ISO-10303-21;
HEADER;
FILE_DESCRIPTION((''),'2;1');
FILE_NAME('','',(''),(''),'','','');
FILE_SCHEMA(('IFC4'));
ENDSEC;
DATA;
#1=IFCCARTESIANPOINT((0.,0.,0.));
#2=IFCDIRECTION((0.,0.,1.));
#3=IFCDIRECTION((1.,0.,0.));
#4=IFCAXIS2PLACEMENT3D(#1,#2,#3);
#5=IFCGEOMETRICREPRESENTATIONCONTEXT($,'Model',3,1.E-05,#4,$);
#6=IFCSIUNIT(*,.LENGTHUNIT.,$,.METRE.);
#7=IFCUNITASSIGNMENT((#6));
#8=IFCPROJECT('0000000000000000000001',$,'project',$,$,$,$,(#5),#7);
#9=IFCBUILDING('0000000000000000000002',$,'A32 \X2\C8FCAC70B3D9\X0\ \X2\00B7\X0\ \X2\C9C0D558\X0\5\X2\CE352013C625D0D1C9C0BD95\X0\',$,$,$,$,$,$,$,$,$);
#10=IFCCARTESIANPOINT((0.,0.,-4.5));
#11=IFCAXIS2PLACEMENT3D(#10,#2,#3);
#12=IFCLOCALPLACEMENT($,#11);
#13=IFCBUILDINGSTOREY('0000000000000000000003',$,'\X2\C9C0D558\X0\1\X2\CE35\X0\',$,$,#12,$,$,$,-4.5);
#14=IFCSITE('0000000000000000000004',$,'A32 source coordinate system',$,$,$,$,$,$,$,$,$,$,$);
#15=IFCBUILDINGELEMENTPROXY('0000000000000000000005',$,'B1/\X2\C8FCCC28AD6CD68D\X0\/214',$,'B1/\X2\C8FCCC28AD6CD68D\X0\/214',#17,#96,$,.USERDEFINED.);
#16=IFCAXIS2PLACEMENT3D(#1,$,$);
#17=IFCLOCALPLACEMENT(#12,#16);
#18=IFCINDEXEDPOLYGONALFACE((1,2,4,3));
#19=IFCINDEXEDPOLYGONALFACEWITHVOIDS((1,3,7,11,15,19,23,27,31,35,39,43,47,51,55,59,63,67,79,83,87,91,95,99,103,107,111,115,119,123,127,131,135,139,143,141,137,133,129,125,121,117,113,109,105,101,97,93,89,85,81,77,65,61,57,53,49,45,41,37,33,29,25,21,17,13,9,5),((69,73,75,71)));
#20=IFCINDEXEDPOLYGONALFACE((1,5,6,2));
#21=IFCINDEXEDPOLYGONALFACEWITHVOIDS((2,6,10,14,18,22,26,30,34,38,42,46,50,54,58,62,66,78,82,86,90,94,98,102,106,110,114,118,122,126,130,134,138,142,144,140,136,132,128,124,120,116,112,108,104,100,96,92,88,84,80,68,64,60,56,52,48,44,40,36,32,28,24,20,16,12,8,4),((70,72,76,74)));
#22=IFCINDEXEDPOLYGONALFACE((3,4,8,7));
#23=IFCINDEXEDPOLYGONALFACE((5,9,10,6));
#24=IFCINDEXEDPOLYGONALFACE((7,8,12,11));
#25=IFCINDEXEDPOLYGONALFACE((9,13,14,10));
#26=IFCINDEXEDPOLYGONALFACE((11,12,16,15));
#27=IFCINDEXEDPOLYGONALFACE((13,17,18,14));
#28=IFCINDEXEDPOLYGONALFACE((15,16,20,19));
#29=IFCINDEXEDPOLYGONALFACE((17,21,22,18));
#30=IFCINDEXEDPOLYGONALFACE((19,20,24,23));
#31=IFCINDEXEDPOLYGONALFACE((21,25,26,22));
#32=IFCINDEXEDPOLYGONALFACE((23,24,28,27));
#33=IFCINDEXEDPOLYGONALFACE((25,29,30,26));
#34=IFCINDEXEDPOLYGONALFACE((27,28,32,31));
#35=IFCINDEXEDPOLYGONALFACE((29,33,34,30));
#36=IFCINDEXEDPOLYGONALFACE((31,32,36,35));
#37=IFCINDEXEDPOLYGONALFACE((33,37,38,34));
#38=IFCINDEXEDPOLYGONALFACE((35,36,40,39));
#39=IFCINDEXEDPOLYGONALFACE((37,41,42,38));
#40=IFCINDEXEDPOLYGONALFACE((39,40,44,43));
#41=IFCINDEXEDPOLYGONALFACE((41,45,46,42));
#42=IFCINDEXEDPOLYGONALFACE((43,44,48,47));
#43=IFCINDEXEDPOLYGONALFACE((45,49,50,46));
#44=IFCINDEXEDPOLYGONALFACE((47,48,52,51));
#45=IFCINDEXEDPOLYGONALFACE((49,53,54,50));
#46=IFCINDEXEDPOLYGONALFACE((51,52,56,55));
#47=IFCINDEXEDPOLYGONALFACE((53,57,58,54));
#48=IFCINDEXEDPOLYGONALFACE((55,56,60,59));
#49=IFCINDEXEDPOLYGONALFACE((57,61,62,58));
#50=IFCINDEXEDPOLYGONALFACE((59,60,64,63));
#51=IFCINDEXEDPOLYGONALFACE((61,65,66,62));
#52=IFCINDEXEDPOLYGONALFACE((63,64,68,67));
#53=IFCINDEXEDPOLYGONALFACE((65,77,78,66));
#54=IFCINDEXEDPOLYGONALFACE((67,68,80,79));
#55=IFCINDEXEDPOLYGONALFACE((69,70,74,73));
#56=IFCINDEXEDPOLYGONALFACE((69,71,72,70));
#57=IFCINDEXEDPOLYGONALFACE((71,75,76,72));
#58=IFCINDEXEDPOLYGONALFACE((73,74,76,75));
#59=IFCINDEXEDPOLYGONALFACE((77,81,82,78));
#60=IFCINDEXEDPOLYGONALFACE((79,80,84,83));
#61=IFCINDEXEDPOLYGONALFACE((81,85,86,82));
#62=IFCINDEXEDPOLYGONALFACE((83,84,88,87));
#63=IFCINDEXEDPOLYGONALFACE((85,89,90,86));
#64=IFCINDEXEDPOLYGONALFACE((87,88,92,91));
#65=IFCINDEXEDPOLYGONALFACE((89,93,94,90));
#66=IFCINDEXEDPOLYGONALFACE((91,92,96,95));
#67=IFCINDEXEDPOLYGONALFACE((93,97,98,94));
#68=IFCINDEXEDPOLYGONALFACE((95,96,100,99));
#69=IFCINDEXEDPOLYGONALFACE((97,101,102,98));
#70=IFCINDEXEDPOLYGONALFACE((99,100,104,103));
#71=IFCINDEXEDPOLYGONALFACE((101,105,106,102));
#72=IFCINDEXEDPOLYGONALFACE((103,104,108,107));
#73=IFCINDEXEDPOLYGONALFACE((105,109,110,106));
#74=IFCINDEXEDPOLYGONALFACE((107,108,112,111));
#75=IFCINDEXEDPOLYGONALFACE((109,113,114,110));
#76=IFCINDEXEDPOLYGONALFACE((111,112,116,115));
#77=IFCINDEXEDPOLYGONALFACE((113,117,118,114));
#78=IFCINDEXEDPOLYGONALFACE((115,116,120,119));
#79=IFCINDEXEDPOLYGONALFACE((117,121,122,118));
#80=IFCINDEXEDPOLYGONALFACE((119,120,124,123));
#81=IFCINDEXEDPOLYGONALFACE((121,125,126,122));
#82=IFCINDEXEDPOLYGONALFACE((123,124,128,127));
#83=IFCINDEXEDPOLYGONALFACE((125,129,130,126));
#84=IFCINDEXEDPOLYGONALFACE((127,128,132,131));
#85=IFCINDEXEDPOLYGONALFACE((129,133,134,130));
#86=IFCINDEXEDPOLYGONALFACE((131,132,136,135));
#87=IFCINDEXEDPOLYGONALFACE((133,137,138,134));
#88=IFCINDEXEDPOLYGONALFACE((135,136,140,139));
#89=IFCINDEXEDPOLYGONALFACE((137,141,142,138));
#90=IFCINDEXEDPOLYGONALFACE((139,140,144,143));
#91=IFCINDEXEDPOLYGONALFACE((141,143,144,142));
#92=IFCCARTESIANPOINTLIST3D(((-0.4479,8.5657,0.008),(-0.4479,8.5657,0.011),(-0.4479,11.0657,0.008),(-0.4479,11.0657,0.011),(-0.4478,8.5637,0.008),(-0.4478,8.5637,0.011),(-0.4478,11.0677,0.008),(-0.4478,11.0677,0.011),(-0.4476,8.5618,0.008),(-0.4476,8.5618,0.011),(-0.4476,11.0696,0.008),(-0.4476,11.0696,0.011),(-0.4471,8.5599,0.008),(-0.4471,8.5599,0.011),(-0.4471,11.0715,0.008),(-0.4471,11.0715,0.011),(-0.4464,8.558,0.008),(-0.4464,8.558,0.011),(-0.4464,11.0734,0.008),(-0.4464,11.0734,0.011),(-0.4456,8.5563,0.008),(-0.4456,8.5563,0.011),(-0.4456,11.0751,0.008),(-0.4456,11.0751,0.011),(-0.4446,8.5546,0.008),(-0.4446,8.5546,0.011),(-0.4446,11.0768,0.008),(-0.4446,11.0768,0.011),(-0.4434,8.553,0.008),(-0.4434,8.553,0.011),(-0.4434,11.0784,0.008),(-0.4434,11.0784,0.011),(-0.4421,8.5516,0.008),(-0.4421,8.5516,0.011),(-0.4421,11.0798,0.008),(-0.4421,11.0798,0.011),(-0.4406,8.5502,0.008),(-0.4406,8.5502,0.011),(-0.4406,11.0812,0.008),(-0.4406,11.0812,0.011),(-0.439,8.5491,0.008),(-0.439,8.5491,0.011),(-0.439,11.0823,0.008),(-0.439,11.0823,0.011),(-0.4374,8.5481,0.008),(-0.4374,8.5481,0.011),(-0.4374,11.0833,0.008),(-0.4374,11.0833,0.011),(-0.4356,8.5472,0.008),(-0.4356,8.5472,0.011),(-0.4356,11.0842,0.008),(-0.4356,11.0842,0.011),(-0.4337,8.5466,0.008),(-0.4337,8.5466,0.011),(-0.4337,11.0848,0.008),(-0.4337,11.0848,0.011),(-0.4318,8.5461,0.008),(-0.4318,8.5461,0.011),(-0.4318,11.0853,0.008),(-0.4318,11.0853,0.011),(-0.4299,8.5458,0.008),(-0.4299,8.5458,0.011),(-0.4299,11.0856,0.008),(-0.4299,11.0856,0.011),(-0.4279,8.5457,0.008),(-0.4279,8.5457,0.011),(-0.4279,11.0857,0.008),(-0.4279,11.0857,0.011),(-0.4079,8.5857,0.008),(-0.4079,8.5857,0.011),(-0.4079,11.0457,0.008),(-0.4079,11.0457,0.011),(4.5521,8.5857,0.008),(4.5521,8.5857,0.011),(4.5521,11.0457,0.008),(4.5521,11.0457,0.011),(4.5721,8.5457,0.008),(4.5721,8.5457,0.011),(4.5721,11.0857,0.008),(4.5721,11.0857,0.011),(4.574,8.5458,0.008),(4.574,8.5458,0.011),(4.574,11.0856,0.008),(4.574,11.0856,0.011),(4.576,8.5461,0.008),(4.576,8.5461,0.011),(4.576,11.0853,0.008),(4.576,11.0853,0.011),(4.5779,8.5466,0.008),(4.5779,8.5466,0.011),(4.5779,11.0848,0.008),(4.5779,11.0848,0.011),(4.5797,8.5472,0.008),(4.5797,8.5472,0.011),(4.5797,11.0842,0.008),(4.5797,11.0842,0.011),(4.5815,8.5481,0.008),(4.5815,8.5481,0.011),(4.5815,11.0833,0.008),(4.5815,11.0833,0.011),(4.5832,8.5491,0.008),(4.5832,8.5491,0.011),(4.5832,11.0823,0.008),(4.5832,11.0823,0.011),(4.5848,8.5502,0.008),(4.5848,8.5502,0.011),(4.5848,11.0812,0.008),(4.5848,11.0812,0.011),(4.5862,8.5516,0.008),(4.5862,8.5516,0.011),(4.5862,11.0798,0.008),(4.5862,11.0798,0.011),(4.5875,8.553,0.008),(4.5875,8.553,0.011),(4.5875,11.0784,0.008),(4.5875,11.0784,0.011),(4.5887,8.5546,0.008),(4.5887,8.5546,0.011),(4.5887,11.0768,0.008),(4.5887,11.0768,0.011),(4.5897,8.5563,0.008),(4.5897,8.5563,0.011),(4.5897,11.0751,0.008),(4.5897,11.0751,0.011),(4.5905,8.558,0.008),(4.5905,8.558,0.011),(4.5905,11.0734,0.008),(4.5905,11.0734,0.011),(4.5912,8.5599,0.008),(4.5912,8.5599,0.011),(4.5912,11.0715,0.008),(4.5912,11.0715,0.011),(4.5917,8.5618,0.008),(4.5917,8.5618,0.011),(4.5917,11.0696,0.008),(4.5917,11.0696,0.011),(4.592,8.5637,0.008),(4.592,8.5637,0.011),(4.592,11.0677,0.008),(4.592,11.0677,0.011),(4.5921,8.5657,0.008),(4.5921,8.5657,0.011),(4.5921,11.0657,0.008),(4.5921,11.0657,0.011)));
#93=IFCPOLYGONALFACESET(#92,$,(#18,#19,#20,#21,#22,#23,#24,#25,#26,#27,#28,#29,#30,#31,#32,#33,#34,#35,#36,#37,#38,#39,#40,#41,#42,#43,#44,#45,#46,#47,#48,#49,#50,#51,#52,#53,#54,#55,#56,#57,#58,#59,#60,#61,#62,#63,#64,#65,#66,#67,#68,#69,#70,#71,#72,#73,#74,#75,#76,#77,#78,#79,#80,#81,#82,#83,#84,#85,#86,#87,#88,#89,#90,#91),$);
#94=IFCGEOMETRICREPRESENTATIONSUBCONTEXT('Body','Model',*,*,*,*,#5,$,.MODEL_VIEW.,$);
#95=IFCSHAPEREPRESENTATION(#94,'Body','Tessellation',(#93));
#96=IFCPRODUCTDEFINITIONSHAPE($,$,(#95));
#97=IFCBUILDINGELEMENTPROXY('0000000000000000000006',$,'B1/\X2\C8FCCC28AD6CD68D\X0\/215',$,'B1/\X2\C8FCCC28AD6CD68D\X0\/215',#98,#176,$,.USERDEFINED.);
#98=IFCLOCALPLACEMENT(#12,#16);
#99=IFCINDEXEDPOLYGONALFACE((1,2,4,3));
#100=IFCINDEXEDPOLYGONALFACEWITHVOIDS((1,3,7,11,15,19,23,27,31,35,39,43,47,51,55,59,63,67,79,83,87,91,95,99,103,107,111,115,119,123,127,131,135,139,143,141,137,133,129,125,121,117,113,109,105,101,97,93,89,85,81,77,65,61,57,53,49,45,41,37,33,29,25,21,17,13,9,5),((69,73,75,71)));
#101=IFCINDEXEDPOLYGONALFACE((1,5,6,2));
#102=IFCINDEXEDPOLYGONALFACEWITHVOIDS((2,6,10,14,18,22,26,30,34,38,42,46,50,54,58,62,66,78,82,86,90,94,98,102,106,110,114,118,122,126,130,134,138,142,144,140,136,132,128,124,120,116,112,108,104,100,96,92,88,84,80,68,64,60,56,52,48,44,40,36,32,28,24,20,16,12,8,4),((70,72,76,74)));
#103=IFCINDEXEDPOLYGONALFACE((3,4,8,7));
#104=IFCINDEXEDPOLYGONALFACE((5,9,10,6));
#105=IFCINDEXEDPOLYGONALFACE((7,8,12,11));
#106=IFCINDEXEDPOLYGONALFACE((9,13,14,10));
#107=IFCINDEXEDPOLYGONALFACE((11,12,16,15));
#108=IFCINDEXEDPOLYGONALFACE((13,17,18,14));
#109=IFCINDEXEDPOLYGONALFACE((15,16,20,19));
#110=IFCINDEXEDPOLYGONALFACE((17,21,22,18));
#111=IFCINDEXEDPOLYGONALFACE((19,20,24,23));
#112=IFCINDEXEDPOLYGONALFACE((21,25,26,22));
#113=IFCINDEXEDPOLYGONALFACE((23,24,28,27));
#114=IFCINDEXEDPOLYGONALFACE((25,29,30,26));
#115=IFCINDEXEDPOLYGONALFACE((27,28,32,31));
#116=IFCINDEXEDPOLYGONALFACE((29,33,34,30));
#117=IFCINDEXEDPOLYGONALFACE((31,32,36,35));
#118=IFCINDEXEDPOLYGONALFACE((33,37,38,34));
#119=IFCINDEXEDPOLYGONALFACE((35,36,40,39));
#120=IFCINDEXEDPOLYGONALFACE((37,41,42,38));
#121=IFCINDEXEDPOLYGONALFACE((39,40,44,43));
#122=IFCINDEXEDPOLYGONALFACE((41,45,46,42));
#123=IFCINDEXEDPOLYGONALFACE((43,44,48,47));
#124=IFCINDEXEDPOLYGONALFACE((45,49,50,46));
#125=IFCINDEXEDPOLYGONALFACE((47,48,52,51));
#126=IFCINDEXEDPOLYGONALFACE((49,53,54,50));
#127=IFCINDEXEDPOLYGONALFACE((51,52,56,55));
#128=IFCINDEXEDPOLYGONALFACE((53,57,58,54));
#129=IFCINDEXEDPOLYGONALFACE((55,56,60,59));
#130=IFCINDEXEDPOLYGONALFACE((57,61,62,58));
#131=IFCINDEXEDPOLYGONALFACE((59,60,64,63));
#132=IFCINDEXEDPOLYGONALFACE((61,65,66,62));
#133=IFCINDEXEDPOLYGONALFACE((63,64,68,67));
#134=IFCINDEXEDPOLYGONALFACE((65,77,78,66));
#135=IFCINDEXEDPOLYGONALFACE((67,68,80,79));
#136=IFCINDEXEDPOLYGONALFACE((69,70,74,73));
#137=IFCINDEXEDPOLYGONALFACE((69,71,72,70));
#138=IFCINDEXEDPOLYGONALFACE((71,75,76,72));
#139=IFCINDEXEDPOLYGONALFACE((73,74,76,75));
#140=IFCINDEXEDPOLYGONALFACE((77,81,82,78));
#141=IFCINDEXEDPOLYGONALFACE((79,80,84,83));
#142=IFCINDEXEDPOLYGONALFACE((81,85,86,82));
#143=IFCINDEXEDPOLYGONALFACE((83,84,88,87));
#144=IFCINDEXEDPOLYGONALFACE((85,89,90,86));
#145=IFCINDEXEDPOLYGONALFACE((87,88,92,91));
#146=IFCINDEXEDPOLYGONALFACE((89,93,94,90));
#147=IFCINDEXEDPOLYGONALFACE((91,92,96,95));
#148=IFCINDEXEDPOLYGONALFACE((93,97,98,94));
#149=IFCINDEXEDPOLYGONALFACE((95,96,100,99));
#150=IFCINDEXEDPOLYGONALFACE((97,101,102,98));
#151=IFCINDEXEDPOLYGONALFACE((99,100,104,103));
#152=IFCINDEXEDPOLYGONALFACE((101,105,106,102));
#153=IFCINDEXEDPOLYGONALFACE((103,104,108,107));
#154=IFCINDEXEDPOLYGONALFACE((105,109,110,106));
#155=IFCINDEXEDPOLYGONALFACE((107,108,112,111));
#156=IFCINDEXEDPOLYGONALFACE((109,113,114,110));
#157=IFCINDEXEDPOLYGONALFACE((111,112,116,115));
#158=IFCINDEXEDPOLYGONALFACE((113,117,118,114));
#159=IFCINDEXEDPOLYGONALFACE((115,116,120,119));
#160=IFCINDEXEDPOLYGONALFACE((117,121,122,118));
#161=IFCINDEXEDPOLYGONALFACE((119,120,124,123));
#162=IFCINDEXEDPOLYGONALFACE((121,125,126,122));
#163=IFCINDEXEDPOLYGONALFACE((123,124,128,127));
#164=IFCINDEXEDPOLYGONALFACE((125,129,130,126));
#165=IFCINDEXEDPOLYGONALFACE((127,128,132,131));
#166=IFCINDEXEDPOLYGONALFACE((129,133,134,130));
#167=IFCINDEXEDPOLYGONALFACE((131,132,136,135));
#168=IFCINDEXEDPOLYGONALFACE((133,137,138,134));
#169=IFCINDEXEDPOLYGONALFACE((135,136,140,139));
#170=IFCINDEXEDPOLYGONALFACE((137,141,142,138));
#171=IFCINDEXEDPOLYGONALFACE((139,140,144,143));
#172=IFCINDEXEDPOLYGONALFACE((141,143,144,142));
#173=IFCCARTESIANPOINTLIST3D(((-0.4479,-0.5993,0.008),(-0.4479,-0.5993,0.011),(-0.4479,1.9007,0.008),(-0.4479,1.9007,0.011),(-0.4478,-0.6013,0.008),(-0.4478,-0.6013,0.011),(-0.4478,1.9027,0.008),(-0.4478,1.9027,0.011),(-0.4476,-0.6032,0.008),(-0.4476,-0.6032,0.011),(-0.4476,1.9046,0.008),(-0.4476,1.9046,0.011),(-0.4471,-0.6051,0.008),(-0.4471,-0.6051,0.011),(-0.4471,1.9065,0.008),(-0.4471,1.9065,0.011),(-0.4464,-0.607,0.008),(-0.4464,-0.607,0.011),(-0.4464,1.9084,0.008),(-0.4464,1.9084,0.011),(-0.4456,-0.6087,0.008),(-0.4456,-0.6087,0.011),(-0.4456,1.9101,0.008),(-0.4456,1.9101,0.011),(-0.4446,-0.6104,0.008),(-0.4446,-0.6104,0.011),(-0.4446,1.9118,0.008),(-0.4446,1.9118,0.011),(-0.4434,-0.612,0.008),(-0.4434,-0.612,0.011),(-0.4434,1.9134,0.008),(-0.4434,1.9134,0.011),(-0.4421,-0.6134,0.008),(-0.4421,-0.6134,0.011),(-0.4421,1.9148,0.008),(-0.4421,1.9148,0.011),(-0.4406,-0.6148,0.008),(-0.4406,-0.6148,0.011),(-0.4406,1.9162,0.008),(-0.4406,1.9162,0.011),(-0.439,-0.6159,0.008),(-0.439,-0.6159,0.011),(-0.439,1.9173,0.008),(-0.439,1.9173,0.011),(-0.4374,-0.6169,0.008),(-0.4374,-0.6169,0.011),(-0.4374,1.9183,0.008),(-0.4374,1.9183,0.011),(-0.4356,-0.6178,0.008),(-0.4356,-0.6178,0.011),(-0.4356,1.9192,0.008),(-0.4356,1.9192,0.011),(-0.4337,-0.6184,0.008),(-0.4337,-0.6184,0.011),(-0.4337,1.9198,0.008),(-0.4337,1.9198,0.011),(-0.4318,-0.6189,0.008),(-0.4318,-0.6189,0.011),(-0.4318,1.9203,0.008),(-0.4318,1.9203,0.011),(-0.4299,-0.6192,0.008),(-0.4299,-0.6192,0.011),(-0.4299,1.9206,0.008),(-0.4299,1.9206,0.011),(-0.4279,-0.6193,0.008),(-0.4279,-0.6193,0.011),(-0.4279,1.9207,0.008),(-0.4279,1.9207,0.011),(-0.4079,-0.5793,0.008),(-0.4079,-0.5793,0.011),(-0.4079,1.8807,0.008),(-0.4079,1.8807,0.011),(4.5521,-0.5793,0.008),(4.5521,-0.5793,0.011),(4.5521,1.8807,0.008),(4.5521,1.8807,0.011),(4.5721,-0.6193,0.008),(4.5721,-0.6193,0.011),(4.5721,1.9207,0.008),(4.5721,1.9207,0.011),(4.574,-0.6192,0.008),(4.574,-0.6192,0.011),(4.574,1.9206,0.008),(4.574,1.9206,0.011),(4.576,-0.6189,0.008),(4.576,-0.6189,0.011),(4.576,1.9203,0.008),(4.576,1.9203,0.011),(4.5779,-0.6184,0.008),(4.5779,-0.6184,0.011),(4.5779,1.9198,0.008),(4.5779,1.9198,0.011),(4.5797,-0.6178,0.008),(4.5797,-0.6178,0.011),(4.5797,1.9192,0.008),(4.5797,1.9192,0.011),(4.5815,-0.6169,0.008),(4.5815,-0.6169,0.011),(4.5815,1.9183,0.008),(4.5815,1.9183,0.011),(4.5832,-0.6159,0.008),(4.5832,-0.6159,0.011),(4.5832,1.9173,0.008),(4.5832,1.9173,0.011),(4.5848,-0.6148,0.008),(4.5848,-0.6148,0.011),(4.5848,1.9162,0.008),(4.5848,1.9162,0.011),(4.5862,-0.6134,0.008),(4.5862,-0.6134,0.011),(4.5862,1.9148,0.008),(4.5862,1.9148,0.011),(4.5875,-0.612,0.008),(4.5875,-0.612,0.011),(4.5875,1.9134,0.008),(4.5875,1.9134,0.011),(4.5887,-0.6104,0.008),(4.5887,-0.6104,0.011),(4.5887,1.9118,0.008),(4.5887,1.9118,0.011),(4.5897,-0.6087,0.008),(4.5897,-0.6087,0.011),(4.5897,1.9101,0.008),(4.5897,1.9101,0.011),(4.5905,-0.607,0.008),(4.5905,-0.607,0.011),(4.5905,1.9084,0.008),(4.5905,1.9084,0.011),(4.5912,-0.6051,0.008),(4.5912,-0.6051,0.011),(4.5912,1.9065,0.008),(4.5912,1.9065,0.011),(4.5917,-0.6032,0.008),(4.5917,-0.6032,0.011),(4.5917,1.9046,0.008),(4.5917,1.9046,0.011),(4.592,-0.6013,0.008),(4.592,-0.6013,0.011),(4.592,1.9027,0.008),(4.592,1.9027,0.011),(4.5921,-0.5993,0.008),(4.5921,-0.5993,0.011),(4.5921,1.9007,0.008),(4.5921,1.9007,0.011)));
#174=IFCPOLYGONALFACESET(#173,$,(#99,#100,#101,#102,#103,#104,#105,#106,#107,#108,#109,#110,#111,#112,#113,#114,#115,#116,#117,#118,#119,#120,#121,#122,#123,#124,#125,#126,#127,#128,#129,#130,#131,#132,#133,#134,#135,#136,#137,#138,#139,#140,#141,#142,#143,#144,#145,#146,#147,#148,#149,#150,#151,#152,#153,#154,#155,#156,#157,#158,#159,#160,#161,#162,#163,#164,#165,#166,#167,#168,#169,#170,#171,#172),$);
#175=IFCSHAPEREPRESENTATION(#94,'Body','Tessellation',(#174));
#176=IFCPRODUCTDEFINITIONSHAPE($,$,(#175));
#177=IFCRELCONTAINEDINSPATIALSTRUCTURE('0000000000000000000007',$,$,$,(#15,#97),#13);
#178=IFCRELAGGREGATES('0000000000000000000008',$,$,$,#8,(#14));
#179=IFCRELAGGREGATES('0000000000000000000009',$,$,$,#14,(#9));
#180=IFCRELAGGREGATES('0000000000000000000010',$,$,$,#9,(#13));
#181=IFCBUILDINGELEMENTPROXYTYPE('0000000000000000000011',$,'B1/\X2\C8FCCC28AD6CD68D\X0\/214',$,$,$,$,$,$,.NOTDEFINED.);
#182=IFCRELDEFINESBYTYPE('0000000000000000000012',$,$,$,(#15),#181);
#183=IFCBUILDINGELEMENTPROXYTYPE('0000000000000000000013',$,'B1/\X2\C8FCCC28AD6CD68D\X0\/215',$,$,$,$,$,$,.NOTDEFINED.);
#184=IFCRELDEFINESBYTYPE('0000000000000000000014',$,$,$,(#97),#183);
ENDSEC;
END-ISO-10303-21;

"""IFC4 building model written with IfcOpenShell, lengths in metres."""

from ifc_helpers import new_model, si_unit, frame, origin, origin_with_axes, place, context, subcontext, project, spatial, polyline, outline, extrude, source, transform, mapped, type_object, type_shapes, element, save


model = new_model("IFC4")

# Units and contexts
model_context = context("Model", 3, precision=1e-05, world=origin_with_axes())
body_context = subcontext(model_context, "Body", "Model", "MODEL_VIEW")
ifc_project = project(units=[si_unit("LENGTHUNIT", "METRE")], contexts=[model_context])

# Site, building, storey
site = spatial("IfcSite", under=ifc_project, Name="A32 source coordinate system")
building = spatial("IfcBuilding", under=site, Name="A32 주거동 · 지하5층–옥탑지붕")
storey_placement = place(None, frame((0.0, 0.0, -4.5), z_axis=(0.0, 0.0, 1.0), x_axis=(1.0, 0.0, 0.0)))
storey = spatial("IfcBuildingStorey", under=building, at=storey_placement, Name="지하1층", Elevation=-4.5)

# Building element proxies
building_element_proxy_type_1 = type_object("IfcBuildingElementProxyType", Name="B1/주차구획/214", PredefinedType="NOTDEFINED")
shared_shape_1 = source(origin(), body_context, "Body", "SweptSolid", [
    extrude(outline(polyline([(-0.4279, 8.5457), (-0.4299, 8.5458), (-0.4318, 8.5461), (-0.4337, 8.5466), (-0.4356, 8.5472), (-0.4374, 8.5481), (-0.439, 8.5491), (-0.4406, 8.5502), (-0.4421, 8.5516), (-0.4434, 8.553), (-0.4446, 8.5546), (-0.4456, 8.5563), (-0.4464, 8.558), (-0.4471, 8.5599), (-0.4476, 8.5618), (-0.4478, 8.5637), (-0.4479, 8.5657), (-0.4479, 11.0657), (-0.4478, 11.0677), (-0.4476, 11.0696), (-0.4471, 11.0715), (-0.4464, 11.0734), (-0.4456, 11.0751), (-0.4446, 11.0768), (-0.4434, 11.0784), (-0.4421, 11.0798), (-0.4406, 11.0812), (-0.439, 11.0823), (-0.4374, 11.0833), (-0.4356, 11.0842), (-0.4337, 11.0848), (-0.4318, 11.0853), (-0.4299, 11.0856), (-0.4279, 11.0857), (4.5721, 11.0857), (4.574, 11.0856), (4.576, 11.0853), (4.5779, 11.0848), (4.5797, 11.0842), (4.5815, 11.0833), (4.5832, 11.0823), (4.5848, 11.0812), (4.5862, 11.0798), (4.5875, 11.0784), (4.5887, 11.0768), (4.5897, 11.0751), (4.5905, 11.0734), (4.5912, 11.0715), (4.5917, 11.0696), (4.592, 11.0677), (4.5921, 11.0657), (4.5921, 8.5657), (4.592, 8.5637), (4.5917, 8.5618), (4.5912, 8.5599), (4.5905, 8.558), (4.5897, 8.5563), (4.5887, 8.5546), (4.5875, 8.553), (4.5862, 8.5516), (4.5848, 8.5502), (4.5832, 8.5491), (4.5815, 8.5481), (4.5797, 8.5472), (4.5779, 8.5466), (4.576, 8.5461), (4.574, 8.5458), (4.5721, 8.5457), (-0.4279, 8.5457)]), holes=[polyline([(-0.4079, 8.5857), (4.5521, 8.5857), (4.5521, 11.0457), (-0.4079, 11.0457), (-0.4079, 8.5857)])]), frame((0.0, 0.0, 0.008)), (0.0, 0.0, 1.0), 0.003),
])
type_shapes(building_element_proxy_type_1, [shared_shape_1])
proxy_1_placement = place(storey_placement, origin_with_axes())
element("IfcBuildingElementProxy", 1, at=proxy_1_placement, inside=storey, type_object=building_element_proxy_type_1, Name="B1/주차구획/214", ObjectType="B1/주차구획/214", PredefinedType="USERDEFINED", context=body_context, shape_type="MappedRepresentation", body=[
    mapped(shared_shape_1, transform((0.0, 0.0, 0.0), scale=1.0)),
])
building_element_proxy_type_2 = type_object("IfcBuildingElementProxyType", Name="B1/주차구획/215", PredefinedType="NOTDEFINED")
shared_shape_2 = source(origin(), body_context, "Body", "SweptSolid", [
    extrude(outline(polyline([(-0.4279, -0.6193), (-0.4299, -0.6192), (-0.4318, -0.6189), (-0.4337, -0.6184), (-0.4356, -0.6178), (-0.4374, -0.6169), (-0.439, -0.6159), (-0.4406, -0.6148), (-0.4421, -0.6134), (-0.4434, -0.612), (-0.4446, -0.6104), (-0.4456, -0.6087), (-0.4464, -0.607), (-0.4471, -0.6051), (-0.4476, -0.6032), (-0.4478, -0.6013), (-0.4479, -0.5993), (-0.4479, 1.9007), (-0.4478, 1.9027), (-0.4476, 1.9046), (-0.4471, 1.9065), (-0.4464, 1.9084), (-0.4456, 1.9101), (-0.4446, 1.9118), (-0.4434, 1.9134), (-0.4421, 1.9148), (-0.4406, 1.9162), (-0.439, 1.9173), (-0.4374, 1.9183), (-0.4356, 1.9192), (-0.4337, 1.9198), (-0.4318, 1.9203), (-0.4299, 1.9206), (-0.4279, 1.9207), (4.5721, 1.9207), (4.574, 1.9206), (4.576, 1.9203), (4.5779, 1.9198), (4.5797, 1.9192), (4.5815, 1.9183), (4.5832, 1.9173), (4.5848, 1.9162), (4.5862, 1.9148), (4.5875, 1.9134), (4.5887, 1.9118), (4.5897, 1.9101), (4.5905, 1.9084), (4.5912, 1.9065), (4.5917, 1.9046), (4.592, 1.9027), (4.5921, 1.9007), (4.5921, -0.5993), (4.592, -0.6013), (4.5917, -0.6032), (4.5912, -0.6051), (4.5905, -0.607), (4.5897, -0.6087), (4.5887, -0.6104), (4.5875, -0.612), (4.5862, -0.6134), (4.5848, -0.6148), (4.5832, -0.6159), (4.5815, -0.6169), (4.5797, -0.6178), (4.5779, -0.6184), (4.576, -0.6189), (4.574, -0.6192), (4.5721, -0.6193), (-0.4279, -0.6193)]), holes=[polyline([(-0.4079, -0.5793), (4.5521, -0.5793), (4.5521, 1.8807), (-0.4079, 1.8807), (-0.4079, -0.5793)])]), frame((0.0, 0.0, 0.008)), (0.0, 0.0, 1.0), 0.003),
])
type_shapes(building_element_proxy_type_2, [shared_shape_2])
proxy_2_placement = place(storey_placement, origin_with_axes())
element("IfcBuildingElementProxy", 2, at=proxy_2_placement, inside=storey, type_object=building_element_proxy_type_2, Name="B1/주차구획/215", ObjectType="B1/주차구획/215", PredefinedType="USERDEFINED", context=body_context, shape_type="MappedRepresentation", body=[
    mapped(shared_shape_2, transform((0.0, 0.0, 0.0), scale=1.0)),
])

save(model, "model.ifc")
